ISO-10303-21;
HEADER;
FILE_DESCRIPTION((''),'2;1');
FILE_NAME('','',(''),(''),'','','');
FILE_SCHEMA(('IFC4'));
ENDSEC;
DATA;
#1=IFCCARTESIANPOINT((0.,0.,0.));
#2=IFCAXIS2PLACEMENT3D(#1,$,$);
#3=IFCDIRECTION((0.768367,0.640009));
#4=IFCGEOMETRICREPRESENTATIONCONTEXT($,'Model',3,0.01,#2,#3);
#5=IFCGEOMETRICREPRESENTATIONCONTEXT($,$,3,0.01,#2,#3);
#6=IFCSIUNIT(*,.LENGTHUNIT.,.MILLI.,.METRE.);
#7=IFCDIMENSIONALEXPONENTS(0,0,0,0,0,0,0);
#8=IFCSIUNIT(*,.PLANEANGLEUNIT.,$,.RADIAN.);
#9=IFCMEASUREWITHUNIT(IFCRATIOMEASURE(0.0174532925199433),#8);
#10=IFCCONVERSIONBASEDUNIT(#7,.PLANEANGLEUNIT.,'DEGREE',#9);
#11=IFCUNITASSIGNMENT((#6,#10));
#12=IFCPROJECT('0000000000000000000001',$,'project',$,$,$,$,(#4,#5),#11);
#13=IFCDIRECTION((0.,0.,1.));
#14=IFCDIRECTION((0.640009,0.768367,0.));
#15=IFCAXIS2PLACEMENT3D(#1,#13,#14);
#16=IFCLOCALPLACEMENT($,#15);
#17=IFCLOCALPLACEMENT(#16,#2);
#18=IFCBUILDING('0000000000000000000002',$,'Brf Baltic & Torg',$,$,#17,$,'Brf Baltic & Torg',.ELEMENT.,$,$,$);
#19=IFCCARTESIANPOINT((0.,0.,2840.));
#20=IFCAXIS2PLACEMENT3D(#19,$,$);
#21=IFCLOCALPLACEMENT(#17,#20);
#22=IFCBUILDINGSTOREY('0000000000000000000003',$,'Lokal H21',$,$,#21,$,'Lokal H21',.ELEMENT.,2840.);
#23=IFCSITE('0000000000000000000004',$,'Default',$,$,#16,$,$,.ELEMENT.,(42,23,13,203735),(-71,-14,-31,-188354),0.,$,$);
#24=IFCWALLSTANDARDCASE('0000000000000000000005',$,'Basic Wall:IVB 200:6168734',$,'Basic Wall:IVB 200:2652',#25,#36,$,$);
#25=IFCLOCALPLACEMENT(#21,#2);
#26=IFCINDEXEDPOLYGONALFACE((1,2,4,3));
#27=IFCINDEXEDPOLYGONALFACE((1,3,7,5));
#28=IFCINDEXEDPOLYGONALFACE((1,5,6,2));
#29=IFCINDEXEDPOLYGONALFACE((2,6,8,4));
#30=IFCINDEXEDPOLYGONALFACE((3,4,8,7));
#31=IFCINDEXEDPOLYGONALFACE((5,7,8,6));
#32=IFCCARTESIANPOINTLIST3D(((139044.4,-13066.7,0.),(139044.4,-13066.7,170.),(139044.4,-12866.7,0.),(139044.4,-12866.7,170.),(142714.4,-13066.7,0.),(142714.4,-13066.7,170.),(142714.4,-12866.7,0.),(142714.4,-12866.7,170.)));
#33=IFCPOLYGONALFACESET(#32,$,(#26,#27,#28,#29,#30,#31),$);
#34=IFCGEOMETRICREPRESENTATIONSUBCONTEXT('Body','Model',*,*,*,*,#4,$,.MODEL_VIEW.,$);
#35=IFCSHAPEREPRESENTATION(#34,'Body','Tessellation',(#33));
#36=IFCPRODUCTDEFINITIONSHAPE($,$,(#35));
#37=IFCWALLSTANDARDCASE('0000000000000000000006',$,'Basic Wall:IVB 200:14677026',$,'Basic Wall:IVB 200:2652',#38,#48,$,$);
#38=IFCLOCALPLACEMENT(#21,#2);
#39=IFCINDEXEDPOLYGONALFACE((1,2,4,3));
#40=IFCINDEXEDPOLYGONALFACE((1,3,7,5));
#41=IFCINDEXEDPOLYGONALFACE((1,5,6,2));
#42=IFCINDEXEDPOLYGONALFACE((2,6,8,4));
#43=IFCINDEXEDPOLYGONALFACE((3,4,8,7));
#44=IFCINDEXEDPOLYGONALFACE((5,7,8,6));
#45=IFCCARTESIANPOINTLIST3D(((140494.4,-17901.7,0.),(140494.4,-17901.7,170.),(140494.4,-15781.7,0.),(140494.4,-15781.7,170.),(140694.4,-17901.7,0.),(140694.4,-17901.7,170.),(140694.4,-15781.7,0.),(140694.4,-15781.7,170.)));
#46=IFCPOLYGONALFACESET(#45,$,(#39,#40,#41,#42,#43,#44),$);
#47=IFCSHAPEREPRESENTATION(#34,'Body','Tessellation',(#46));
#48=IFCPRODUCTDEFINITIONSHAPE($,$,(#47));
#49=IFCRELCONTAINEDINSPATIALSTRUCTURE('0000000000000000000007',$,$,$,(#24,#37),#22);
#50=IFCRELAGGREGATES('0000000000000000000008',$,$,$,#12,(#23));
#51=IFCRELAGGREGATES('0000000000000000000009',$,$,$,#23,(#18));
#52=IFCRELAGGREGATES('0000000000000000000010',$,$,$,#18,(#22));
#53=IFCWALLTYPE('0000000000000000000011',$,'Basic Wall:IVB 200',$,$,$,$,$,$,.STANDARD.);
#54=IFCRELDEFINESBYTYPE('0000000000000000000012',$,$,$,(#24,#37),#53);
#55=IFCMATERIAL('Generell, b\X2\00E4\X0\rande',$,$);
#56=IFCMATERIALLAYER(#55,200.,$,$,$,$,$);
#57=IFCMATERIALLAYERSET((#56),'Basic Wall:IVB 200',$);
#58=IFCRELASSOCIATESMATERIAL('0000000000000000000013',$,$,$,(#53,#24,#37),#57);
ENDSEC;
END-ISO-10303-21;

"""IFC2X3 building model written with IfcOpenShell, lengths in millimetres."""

from ifc_helpers import new_model, entity, si_unit, converted_unit, direction, frame, frame_2d, origin, place, context, subcontext, project, spatial, rectangle, extrude, clip, halfspace, material, layer, layer_set, layer_usage, type_object, element, save


model = new_model("IFC2X3")

# Units and contexts
model_context = context("Model", 3, precision=0.01, world=origin(), true_north=direction((0.768367, 0.640009)))
context_of_model = context(None, 3, precision=0.01, world=origin(), true_north=direction((0.768367, 0.640009)))
body_context = subcontext(model_context, "Body", "Model", "MODEL_VIEW")
ifc_project = project(units=[si_unit("LENGTHUNIT", "METRE", prefix="MILLI"), converted_unit("PLANEANGLEUNIT", "DEGREE", entity("IfcRatioMeasure", 0.0174532925199433), si_unit("PLANEANGLEUNIT", "RADIAN"), dimensions=[0, 0, 0, 0, 0, 0, 0])], contexts=[model_context, context_of_model])

# Site, building, storey
site_placement = place(None, frame((0.0, 0.0, 0.0), z_axis=(0.0, 0.0, 1.0), x_axis=(0.640009, 0.768367, 0.0)))
site = spatial("IfcSite", under=ifc_project, at=site_placement, Name="Default", CompositionType="ELEMENT", RefLatitude=(42, 23, 13, 203735), RefLongitude=(-71, -14, -31, -188354), RefElevation=0.0)
building_placement = place(site_placement, origin())
building = spatial("IfcBuilding", under=site, at=building_placement, Name="Brf Baltic & Torg", LongName="Brf Baltic & Torg", CompositionType="ELEMENT")
storey_placement = place(building_placement, frame((0.0, 0.0, 2840.0)))
storey = spatial("IfcBuildingStorey", under=building, at=storey_placement, Name="Lokal H21", LongName="Lokal H21", CompositionType="ELEMENT", Elevation=2840.0)

# Shared definitions
ifc_material_1 = material(Name="Generell, bärande")
ifc_layer_1 = layer(ifc_material_1, 200.0)
ifc_layer_set_1 = layer_set([ifc_layer_1], Name="Basic Wall:IVB 200")
wall_type_1 = type_object("IfcWallType", Name="Basic Wall:IVB 200", PredefinedType="STANDARD", material=ifc_layer_set_1)

# Walls
ifc_layer_usage_1 = layer_usage(ifc_layer_set_1, "AXIS2", "NEGATIVE", 100.0)
wall_1_placement = place(storey_placement, frame((142714.4, -12966.7, 0.0), z_axis=(0.0, 0.0, 1.0), x_axis=(-1.0, 0.0, 0.0)))
element("IfcWallStandardCase", 1, at=wall_1_placement, inside=storey, type_object=wall_type_1, material=ifc_layer_usage_1, Name="Basic Wall:IVB 200:6168734", ObjectType="Basic Wall:IVB 200:2652", context=body_context, shape_type="Clipping", body=[
    clip(extrude(rectangle(XDim=3670.0, YDim=200.0, at=frame_2d((1835.0, 0.0), x_axis=(-1.0, 0.0))), origin(), (0.0, 0.0, 1.0), 170.0), halfspace(frame((0.0, 0.0, -1190.0)), True)),
])
ifc_layer_usage_2 = layer_usage(ifc_layer_set_1, "AXIS2", "NEGATIVE", 100.0)
wall_2_placement = place(storey_placement, frame((140594.4, -15781.7, 0.0), z_axis=(0.0, 0.0, 1.0), x_axis=(0.0, -1.0, 0.0)))
element("IfcWallStandardCase", 2, at=wall_2_placement, inside=storey, type_object=wall_type_1, material=ifc_layer_usage_2, Name="Basic Wall:IVB 200:14677026", ObjectType="Basic Wall:IVB 200:2652", context=body_context, shape_type="Clipping", body=[
    clip(extrude(rectangle(XDim=2120.0, YDim=200.0, at=frame_2d((1060.0, 0.0), x_axis=(-1.0, 0.0))), origin(), (0.0, 0.0, 1.0), 170.0), halfspace(frame((0.0, 0.0, -1190.0)), True)),
])

save(model, "model.ifc")
